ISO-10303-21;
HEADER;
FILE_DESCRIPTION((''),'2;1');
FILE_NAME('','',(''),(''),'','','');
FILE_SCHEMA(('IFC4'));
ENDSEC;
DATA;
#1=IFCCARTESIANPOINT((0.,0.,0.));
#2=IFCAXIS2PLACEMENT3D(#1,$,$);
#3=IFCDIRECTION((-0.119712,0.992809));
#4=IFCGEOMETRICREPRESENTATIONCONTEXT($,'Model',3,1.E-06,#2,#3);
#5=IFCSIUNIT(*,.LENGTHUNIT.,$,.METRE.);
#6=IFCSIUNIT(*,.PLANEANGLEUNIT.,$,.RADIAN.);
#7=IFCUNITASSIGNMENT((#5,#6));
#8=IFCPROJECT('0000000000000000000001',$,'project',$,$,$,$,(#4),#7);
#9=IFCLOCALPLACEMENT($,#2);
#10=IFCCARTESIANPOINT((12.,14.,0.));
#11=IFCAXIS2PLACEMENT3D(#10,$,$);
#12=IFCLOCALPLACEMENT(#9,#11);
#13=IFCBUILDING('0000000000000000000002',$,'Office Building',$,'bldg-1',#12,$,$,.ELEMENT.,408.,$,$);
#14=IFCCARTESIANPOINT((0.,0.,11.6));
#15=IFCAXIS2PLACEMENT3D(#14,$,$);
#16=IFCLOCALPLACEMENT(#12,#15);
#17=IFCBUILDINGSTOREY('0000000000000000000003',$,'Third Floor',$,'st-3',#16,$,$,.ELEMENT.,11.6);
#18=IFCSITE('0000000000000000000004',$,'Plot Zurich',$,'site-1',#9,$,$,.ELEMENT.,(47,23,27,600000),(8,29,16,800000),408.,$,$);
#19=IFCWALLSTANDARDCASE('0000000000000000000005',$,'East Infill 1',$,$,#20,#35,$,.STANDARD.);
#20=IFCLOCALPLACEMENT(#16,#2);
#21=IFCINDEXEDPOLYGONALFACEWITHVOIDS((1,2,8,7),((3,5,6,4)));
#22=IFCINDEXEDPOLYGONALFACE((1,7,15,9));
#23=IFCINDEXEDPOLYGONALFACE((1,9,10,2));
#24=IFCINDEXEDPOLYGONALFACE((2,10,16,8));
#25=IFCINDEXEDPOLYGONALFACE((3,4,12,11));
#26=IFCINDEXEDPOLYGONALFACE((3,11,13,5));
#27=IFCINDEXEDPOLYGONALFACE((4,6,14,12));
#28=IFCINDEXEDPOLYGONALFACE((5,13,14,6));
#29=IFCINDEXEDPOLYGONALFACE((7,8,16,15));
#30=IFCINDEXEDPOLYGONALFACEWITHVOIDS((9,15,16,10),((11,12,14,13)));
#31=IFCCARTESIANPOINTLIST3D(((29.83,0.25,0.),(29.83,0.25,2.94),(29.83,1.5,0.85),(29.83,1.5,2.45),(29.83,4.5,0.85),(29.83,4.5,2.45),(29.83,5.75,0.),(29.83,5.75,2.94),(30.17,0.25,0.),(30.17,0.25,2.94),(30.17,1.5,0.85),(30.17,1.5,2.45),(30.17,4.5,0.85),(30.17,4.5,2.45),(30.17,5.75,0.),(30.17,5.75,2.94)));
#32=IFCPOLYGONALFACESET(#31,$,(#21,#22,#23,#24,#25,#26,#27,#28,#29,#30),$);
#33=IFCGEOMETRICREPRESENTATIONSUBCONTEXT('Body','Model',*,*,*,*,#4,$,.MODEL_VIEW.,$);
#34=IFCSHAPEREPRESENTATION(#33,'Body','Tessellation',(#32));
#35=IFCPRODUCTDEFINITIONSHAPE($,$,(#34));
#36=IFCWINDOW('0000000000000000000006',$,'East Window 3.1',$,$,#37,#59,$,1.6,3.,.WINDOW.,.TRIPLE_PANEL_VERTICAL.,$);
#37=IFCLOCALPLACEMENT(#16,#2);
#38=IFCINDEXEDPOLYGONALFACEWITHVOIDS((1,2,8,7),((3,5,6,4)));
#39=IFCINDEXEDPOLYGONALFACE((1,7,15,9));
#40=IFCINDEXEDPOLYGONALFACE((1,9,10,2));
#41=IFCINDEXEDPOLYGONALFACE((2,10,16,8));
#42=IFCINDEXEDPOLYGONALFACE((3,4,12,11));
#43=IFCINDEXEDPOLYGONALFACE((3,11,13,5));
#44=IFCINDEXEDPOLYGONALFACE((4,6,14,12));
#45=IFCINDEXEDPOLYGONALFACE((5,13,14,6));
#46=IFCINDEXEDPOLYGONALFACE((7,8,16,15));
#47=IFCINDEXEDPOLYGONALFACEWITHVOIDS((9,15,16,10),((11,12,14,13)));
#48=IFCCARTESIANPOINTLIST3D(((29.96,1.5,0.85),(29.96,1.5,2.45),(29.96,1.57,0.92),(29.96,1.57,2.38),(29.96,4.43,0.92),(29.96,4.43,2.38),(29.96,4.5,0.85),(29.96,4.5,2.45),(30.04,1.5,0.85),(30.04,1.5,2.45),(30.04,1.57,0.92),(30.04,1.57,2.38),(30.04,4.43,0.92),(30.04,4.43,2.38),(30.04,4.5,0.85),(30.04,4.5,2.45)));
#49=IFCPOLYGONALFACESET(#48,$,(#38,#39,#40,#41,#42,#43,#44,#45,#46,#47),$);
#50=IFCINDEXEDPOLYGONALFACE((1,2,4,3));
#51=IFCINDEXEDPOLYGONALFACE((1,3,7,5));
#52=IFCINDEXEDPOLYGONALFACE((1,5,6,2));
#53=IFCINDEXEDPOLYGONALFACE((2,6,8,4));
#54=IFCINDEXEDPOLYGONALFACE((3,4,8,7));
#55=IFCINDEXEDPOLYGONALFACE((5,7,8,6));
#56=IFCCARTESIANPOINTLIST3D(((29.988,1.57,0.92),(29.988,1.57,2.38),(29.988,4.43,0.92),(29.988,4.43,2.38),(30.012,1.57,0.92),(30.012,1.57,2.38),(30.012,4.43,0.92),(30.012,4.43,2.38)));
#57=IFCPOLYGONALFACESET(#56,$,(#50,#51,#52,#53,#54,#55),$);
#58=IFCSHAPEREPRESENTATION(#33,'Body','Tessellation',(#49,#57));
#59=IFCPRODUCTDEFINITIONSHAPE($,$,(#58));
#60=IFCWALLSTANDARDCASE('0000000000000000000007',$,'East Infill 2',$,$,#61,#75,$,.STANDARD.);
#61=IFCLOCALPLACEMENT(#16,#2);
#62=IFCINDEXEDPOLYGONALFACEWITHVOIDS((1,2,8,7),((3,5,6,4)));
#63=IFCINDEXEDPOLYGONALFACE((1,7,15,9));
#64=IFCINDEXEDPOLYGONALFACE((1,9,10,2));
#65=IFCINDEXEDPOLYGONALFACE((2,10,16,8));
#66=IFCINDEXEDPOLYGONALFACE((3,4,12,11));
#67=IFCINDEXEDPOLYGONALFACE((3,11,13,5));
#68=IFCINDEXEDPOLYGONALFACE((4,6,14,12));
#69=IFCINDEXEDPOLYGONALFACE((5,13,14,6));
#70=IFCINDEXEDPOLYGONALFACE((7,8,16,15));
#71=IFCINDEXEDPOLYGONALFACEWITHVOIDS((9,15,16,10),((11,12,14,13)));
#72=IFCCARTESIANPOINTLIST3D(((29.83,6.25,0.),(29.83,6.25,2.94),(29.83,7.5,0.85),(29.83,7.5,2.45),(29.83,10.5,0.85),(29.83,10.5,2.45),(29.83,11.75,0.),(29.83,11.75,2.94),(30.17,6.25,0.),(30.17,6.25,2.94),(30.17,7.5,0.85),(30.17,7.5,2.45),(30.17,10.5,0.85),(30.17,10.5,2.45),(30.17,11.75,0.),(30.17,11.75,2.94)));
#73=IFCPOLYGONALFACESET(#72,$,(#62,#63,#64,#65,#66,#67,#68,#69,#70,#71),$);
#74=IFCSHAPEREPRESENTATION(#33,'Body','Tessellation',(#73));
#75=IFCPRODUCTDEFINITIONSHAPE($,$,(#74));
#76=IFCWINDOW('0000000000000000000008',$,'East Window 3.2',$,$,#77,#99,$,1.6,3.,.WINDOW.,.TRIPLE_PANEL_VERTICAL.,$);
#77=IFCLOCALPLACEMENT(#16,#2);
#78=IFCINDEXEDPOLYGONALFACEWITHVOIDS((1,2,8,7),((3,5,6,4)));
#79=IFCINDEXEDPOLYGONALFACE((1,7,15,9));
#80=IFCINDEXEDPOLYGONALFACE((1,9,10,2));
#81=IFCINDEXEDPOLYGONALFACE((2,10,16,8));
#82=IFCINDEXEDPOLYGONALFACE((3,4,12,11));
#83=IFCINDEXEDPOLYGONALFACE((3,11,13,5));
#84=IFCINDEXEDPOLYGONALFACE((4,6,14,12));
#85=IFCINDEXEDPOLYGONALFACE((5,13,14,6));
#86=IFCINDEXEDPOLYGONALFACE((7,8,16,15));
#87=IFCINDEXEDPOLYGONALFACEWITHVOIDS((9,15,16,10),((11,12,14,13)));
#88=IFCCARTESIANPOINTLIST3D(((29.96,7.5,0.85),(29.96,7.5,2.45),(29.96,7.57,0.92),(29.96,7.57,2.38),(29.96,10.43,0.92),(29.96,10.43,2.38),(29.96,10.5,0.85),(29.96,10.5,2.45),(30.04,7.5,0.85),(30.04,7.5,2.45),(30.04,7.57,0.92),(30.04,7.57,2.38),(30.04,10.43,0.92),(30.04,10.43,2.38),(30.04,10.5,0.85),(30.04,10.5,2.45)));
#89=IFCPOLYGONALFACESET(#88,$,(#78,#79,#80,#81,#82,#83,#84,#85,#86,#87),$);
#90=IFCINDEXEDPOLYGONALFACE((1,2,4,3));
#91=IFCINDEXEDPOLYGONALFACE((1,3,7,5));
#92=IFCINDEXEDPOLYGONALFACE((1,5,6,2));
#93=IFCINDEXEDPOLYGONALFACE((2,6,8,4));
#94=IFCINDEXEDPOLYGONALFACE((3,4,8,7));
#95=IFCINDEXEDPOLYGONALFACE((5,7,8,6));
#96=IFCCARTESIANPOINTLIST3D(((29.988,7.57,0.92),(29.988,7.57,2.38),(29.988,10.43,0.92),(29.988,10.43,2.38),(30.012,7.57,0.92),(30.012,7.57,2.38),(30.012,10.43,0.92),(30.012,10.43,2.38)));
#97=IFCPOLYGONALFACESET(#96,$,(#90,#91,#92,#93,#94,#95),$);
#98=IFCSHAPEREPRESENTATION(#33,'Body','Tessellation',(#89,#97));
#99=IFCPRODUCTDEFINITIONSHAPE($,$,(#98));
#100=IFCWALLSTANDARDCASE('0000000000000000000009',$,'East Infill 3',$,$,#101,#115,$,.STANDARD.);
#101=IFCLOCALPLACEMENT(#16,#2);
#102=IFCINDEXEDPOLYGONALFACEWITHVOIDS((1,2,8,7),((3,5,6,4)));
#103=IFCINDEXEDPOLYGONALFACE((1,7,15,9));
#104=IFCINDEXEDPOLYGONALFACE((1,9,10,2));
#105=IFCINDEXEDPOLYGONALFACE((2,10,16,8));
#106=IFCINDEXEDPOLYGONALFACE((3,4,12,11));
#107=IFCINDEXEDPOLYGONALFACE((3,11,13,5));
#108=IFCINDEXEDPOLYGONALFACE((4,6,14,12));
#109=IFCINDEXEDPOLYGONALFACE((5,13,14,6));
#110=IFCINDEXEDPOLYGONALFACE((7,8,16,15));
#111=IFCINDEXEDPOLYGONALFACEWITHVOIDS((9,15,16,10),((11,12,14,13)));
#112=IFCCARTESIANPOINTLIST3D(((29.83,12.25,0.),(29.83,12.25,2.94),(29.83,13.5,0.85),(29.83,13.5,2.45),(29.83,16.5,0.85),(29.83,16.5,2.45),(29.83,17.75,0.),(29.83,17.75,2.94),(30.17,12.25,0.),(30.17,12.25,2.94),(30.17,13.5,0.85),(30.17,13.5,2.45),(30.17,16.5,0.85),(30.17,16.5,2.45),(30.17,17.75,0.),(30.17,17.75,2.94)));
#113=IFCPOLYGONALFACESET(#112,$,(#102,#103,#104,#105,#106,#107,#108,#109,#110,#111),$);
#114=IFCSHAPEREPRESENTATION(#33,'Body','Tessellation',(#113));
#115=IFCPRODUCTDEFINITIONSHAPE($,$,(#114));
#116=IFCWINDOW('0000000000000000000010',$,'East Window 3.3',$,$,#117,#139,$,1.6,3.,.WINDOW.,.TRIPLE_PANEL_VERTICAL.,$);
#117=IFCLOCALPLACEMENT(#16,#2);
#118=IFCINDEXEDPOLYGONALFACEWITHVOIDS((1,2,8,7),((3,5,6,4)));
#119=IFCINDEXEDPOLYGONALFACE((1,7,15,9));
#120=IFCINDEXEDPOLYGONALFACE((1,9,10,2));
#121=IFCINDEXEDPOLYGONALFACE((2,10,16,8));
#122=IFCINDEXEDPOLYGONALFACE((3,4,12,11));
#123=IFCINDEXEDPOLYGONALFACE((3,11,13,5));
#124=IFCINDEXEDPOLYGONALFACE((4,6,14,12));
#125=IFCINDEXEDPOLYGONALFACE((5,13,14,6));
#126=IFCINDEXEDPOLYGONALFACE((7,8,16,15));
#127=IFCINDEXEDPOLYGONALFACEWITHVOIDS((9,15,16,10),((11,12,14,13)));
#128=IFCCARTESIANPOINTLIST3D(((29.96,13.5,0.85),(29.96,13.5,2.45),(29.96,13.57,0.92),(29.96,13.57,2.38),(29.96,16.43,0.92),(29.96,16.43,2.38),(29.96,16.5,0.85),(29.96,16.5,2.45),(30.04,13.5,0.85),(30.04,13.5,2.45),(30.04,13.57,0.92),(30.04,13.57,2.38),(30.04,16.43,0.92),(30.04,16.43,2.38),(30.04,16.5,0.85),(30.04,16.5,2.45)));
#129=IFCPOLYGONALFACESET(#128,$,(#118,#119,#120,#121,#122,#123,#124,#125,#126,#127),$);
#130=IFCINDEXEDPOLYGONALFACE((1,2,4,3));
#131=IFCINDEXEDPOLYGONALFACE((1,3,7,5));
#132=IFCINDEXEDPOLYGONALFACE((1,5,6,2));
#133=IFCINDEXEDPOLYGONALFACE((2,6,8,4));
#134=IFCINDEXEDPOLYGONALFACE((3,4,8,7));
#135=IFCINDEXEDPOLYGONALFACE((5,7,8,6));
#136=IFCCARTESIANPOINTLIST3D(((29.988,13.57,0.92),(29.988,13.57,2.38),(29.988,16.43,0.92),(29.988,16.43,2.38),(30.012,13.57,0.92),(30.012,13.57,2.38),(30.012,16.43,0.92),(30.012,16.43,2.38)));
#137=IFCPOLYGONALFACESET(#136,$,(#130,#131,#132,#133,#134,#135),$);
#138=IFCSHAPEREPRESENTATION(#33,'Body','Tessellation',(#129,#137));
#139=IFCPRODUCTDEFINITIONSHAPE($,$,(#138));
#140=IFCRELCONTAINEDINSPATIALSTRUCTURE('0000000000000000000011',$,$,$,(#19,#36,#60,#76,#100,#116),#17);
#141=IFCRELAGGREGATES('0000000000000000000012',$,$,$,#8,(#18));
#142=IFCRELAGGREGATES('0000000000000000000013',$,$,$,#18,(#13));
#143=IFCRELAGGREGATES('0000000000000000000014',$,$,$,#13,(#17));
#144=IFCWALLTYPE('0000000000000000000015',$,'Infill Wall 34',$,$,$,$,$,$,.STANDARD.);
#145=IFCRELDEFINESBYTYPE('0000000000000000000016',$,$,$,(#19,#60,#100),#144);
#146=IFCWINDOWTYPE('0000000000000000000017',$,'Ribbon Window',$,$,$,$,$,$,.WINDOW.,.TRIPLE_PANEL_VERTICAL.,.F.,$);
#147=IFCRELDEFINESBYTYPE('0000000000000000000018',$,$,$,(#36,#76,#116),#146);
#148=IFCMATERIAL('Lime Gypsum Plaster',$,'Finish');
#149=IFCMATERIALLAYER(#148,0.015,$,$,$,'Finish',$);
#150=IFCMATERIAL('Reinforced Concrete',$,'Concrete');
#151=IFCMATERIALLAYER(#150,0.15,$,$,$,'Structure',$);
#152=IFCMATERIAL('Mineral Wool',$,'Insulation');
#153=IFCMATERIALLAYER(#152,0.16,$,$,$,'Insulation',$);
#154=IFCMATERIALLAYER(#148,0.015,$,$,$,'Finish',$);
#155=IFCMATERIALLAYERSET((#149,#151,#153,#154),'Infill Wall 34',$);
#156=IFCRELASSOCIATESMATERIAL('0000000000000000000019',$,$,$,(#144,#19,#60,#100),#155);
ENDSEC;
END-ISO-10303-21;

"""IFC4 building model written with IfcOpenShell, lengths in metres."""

from ifc_helpers import new_model, si_unit, direction, frame, frame_2d, origin, origin_2d, place, context, subcontext, project, spatial, polyline, rectangle, outline, extrude, material, layer, layer_set, layer_usage, type_object, element, fill, save


model = new_model("IFC4")

# Units and contexts
model_context = context("Model", 3, precision=1e-06, world=origin(), true_north=direction((-0.119712, 0.992809)))
body_context = subcontext(model_context, "Body", "Model", "MODEL_VIEW")
ifc_project = project(units=[si_unit("LENGTHUNIT", "METRE"), si_unit("PLANEANGLEUNIT", "RADIAN")], contexts=[model_context])

# Site, building, storey
site_placement = place(None, origin())
site = spatial("IfcSite", under=ifc_project, at=site_placement, Name="Plot Zurich", ObjectType="site-1", CompositionType="ELEMENT", RefLatitude=(47, 23, 27, 600000), RefLongitude=(8, 29, 16, 800000), RefElevation=408.0)
building_placement = place(site_placement, frame((12.0, 14.0, 0.0)))
building = spatial("IfcBuilding", under=site, at=building_placement, Name="Office Building", ObjectType="bldg-1", CompositionType="ELEMENT", ElevationOfRefHeight=408.0)
storey_placement = place(building_placement, frame((0.0, 0.0, 11.6)))
storey = spatial("IfcBuildingStorey", under=building, at=storey_placement, Name="Third Floor", ObjectType="st-3", CompositionType="ELEMENT", Elevation=11.6)

# Shared definitions
ifc_material_1 = material(Name="Reinforced Concrete", Category="Concrete")

# Walls, openings, windows
ifc_material_2 = material(Name="Lime Gypsum Plaster", Category="Finish")
ifc_layer_1 = layer(ifc_material_2, 0.015, Category="Finish")
ifc_layer_2 = layer(ifc_material_1, 0.15, Category="Structure")
ifc_material_3 = material(Name="Mineral Wool", Category="Insulation")
ifc_layer_3 = layer(ifc_material_3, 0.16, Category="Insulation")
ifc_layer_4 = layer(ifc_material_2, 0.015, Category="Finish")
ifc_layer_set = layer_set([ifc_layer_1, ifc_layer_2, ifc_layer_3, ifc_layer_4], Name="Infill Wall 34")
ifc_layer_usage_1 = layer_usage(ifc_layer_set, "AXIS2", "NEGATIVE", 0.17)
wall_type = type_object("IfcWallType", Name="Infill Wall 34", PredefinedType="STANDARD", material=ifc_layer_set)
wall_1_placement = place(storey_placement, frame((30.0, 0.25, 0.0), z_axis=(0.0, 0.0, 1.0), x_axis=(0.0, 1.0, 0.0)))
wall_1 = element("IfcWallStandardCase", 1, at=wall_1_placement, inside=storey, type_object=wall_type, material=ifc_layer_usage_1, Name="East Infill 1", PredefinedType="STANDARD", context=body_context, shape_type="SweptSolid", body=[
    extrude(rectangle(XDim=5.5, YDim=0.34, at=frame_2d((2.75, 0.0))), origin(), (0.0, 0.0, 1.0), 2.94),
])
opening_1_placement = place(wall_1_placement, frame((2.75, 0.0, 0.85)))
opening_1 = element("IfcOpeningElement", 2, at=opening_1_placement, cuts=wall_1, PredefinedType="OPENING", context=body_context, shape_type="SweptSolid", body=[
    extrude(rectangle(XDim=3.0, YDim=0.34, at=origin_2d()), origin(), (0.0, 0.0, 1.0), 1.6),
])
window_type = type_object("IfcWindowType", Name="Ribbon Window", ParameterTakesPrecedence=False, PartitioningType="TRIPLE_PANEL_VERTICAL", PredefinedType="WINDOW")
window_1_placement = place(opening_1_placement, frame((0.0, 0.0, 0.0), z_axis=(0.0, 1.0, 0.0), x_axis=(-1.0, 0.0, 0.0)))
window_1 = element("IfcWindow", 3, at=window_1_placement, inside=storey, type_object=window_type, Name="East Window 3.1", OverallHeight=1.6, OverallWidth=3.0, PartitioningType="TRIPLE_PANEL_VERTICAL", PredefinedType="WINDOW", context=body_context, shape_type="SweptSolid", body=[
    extrude(outline(polyline([(-1.5, 0.0), (1.5, 0.0), (1.5, 1.6), (-1.5, 1.6), (-1.5, 0.0)]), holes=[polyline([(-1.43, 0.07), (1.43, 0.07), (1.43, 1.53), (-1.43, 1.53), (-1.43, 0.07)])]), frame((0.0, 0.0, -0.04)), (0.0, 0.0, 1.0), 0.08),
    extrude(rectangle(XDim=2.86, YDim=1.46, at=frame_2d((0.0, 0.8))), frame((0.0, 0.0, -0.012)), (0.0, 0.0, 1.0), 0.024),
])
fill(opening_1, window_1)
ifc_layer_usage_2 = layer_usage(ifc_layer_set, "AXIS2", "NEGATIVE", 0.17)
wall_2_placement = place(storey_placement, frame((30.0, 6.25, 0.0), z_axis=(0.0, 0.0, 1.0), x_axis=(0.0, 1.0, 0.0)))
wall_2 = element("IfcWallStandardCase", 4, at=wall_2_placement, inside=storey, type_object=wall_type, material=ifc_layer_usage_2, Name="East Infill 2", PredefinedType="STANDARD", context=body_context, shape_type="SweptSolid", body=[
    extrude(rectangle(XDim=5.5, YDim=0.34, at=frame_2d((2.75, 0.0))), origin(), (0.0, 0.0, 1.0), 2.94),
])
opening_2_placement = place(wall_2_placement, frame((2.75, 0.0, 0.85)))
opening_2 = element("IfcOpeningElement", 5, at=opening_2_placement, cuts=wall_2, PredefinedType="OPENING", context=body_context, shape_type="SweptSolid", body=[
    extrude(rectangle(XDim=3.0, YDim=0.34, at=origin_2d()), origin(), (0.0, 0.0, 1.0), 1.6),
])
window_2_placement = place(opening_2_placement, frame((0.0, 0.0, 0.0), z_axis=(0.0, 1.0, 0.0), x_axis=(-1.0, 0.0, 0.0)))
window_2 = element("IfcWindow", 6, at=window_2_placement, inside=storey, type_object=window_type, Name="East Window 3.2", OverallHeight=1.6, OverallWidth=3.0, PartitioningType="TRIPLE_PANEL_VERTICAL", PredefinedType="WINDOW", context=body_context, shape_type="SweptSolid", body=[
    extrude(outline(polyline([(-1.5, 0.0), (1.5, 0.0), (1.5, 1.6), (-1.5, 1.6), (-1.5, 0.0)]), holes=[polyline([(-1.43, 0.07), (1.43, 0.07), (1.43, 1.53), (-1.43, 1.53), (-1.43, 0.07)])]), frame((0.0, 0.0, -0.04)), (0.0, 0.0, 1.0), 0.08),
    extrude(rectangle(XDim=2.86, YDim=1.46, at=frame_2d((0.0, 0.8))), frame((0.0, 0.0, -0.012)), (0.0, 0.0, 1.0), 0.024),
])
fill(opening_2, window_2)
ifc_layer_usage_3 = layer_usage(ifc_layer_set, "AXIS2", "NEGATIVE", 0.17)
wall_3_placement = place(storey_placement, frame((30.0, 12.25, 0.0), z_axis=(0.0, 0.0, 1.0), x_axis=(0.0, 1.0, 0.0)))
wall_3 = element("IfcWallStandardCase", 7, at=wall_3_placement, inside=storey, type_object=wall_type, material=ifc_layer_usage_3, Name="East Infill 3", PredefinedType="STANDARD", context=body_context, shape_type="SweptSolid", body=[
    extrude(rectangle(XDim=5.5, YDim=0.34, at=frame_2d((2.75, 0.0))), origin(), (0.0, 0.0, 1.0), 2.94),
])
opening_3_placement = place(wall_3_placement, frame((2.75, 0.0, 0.85)))
opening_3 = element("IfcOpeningElement", 8, at=opening_3_placement, cuts=wall_3, PredefinedType="OPENING", context=body_context, shape_type="SweptSolid", body=[
    extrude(rectangle(XDim=3.0, YDim=0.34, at=origin_2d()), origin(), (0.0, 0.0, 1.0), 1.6),
])
window_3_placement = place(opening_3_placement, frame((0.0, 0.0, 0.0), z_axis=(0.0, 1.0, 0.0), x_axis=(-1.0, 0.0, 0.0)))
window_3 = element("IfcWindow", 9, at=window_3_placement, inside=storey, type_object=window_type, Name="East Window 3.3", OverallHeight=1.6, OverallWidth=3.0, PartitioningType="TRIPLE_PANEL_VERTICAL", PredefinedType="WINDOW", context=body_context, shape_type="SweptSolid", body=[
    extrude(outline(polyline([(-1.5, 0.0), (1.5, 0.0), (1.5, 1.6), (-1.5, 1.6), (-1.5, 0.0)]), holes=[polyline([(-1.43, 0.07), (1.43, 0.07), (1.43, 1.53), (-1.43, 1.53), (-1.43, 0.07)])]), frame((0.0, 0.0, -0.04)), (0.0, 0.0, 1.0), 0.08),
    extrude(rectangle(XDim=2.86, YDim=1.46, at=frame_2d((0.0, 0.8))), frame((0.0, 0.0, -0.012)), (0.0, 0.0, 1.0), 0.024),
])
fill(opening_3, window_3)

save(model, "model.ifc")
